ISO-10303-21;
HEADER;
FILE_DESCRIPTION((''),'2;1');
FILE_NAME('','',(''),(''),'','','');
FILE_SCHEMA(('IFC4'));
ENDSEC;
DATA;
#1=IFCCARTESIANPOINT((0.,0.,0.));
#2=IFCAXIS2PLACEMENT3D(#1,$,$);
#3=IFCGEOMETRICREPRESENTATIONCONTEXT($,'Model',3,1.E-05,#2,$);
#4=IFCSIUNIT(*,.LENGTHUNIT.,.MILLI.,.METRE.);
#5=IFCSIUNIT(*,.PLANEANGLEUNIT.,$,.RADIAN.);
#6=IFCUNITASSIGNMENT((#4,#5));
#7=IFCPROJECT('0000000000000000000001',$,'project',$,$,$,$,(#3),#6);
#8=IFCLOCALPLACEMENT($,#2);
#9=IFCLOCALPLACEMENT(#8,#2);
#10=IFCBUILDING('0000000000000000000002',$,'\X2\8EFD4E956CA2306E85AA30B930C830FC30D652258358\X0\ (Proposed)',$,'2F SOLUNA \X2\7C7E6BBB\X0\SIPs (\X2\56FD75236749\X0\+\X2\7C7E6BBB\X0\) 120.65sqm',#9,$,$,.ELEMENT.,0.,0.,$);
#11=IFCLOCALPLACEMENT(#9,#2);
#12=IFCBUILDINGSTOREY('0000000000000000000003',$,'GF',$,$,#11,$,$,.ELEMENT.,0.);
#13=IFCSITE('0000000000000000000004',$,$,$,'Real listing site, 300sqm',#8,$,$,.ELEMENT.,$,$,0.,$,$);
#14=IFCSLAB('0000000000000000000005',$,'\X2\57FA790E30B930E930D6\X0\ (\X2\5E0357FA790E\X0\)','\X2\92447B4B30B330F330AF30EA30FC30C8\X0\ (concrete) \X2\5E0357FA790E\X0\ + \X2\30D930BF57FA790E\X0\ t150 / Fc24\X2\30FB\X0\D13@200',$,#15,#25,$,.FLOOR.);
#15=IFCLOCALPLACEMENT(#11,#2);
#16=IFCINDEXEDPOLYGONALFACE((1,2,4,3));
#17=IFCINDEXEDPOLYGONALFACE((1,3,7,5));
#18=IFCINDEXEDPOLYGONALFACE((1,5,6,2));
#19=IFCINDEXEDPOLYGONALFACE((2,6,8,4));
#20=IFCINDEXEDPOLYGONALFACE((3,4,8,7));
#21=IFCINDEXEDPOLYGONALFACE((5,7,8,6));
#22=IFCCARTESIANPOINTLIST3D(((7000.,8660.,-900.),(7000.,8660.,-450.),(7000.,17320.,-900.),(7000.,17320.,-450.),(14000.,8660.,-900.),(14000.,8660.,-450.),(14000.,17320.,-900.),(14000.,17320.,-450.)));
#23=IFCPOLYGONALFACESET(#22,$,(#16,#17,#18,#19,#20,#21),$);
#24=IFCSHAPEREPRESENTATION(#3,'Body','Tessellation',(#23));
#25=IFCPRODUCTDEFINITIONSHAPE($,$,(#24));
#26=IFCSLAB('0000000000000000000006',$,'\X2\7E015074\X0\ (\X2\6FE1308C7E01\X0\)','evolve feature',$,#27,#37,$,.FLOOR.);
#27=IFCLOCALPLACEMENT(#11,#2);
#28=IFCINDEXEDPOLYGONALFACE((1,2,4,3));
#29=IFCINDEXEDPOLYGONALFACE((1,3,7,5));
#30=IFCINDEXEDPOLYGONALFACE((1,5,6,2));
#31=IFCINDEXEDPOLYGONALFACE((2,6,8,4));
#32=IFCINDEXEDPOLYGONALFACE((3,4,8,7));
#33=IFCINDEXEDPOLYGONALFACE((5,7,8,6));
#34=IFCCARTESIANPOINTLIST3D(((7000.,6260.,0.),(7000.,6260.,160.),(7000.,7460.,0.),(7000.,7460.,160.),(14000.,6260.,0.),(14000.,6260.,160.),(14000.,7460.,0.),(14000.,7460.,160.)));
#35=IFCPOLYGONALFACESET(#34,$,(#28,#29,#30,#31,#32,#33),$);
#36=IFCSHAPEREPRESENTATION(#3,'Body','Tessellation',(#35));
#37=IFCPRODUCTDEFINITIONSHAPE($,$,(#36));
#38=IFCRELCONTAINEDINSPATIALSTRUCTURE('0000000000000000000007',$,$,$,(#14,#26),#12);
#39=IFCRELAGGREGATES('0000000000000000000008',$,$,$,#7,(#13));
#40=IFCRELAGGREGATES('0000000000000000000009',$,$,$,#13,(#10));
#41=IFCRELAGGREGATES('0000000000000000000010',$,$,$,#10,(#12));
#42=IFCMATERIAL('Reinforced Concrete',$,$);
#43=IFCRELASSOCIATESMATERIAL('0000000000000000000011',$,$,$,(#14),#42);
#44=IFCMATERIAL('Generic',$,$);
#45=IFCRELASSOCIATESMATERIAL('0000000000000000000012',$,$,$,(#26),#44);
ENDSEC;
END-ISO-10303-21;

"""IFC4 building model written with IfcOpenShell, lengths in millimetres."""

from ifc_helpers import new_model, si_unit, frame, frame_2d, origin, place, context, project, spatial, rectangle, extrude, material, element, save


model = new_model("IFC4")

# Units and contexts
model_context = context("Model", 3, precision=1e-05, world=origin())
ifc_project = project(units=[si_unit("LENGTHUNIT", "METRE", prefix="MILLI"), si_unit("PLANEANGLEUNIT", "RADIAN")], contexts=[model_context])

# Site, building, storey
site_placement = place(None, origin())
site = spatial("IfcSite", under=ifc_project, at=site_placement, ObjectType="Real listing site, 300sqm", CompositionType="ELEMENT", RefElevation=0.0)
building_placement = place(site_placement, origin())
building = spatial("IfcBuilding", under=site, at=building_placement, Name="軽井沢の薪ストーブ別荘 (Proposed)", ObjectType="2F SOLUNA 籾殻SIPs (国産杉+籾殻) 120.65sqm", CompositionType="ELEMENT", ElevationOfRefHeight=0.0, ElevationOfTerrain=0.0)
storey_placement = place(building_placement, origin())
storey = spatial("IfcBuildingStorey", under=building, at=storey_placement, Name="GF", CompositionType="ELEMENT", Elevation=0.0)

# Slabs
ifc_material_1 = material(Name="Reinforced Concrete")
slab_1_placement = place(storey_placement, frame((3500.0, 4330.0, -450.0)))
element("IfcSlab", 1, at=slab_1_placement, inside=storey, material=ifc_material_1, Name="基礎スラブ (布基礎)", Description="鉄筋コンクリート (concrete) 布基礎 + ベタ基礎 t150 / Fc24・D13@200", PredefinedType="FLOOR", context=model_context, shape_type="SweptSolid", body=[
    extrude(rectangle(XDim=7000.0, YDim=8660.0, at=frame_2d((3500.0, 4330.0))), frame((3500.0, 4330.0, -450.0)), (0.0, 0.0, 1.0), 450.0),
])
ifc_material_2 = material(Name="Generic")
slab_2_placement = place(storey_placement, frame((3500.0, 3130.0, 0.0)))
element("IfcSlab", 2, at=slab_2_placement, inside=storey, material=ifc_material_2, Name="縁側 (濡れ縁)", Description="evolve feature", PredefinedType="FLOOR", context=model_context, shape_type="SweptSolid", body=[
    extrude(rectangle(XDim=7000.0, YDim=1200.0, at=frame_2d((3500.0, 600.0))), frame((3500.0, 3130.0, 0.0)), (0.0, 0.0, 1.0), 160.0),
])

save(model, "model.ifc")
